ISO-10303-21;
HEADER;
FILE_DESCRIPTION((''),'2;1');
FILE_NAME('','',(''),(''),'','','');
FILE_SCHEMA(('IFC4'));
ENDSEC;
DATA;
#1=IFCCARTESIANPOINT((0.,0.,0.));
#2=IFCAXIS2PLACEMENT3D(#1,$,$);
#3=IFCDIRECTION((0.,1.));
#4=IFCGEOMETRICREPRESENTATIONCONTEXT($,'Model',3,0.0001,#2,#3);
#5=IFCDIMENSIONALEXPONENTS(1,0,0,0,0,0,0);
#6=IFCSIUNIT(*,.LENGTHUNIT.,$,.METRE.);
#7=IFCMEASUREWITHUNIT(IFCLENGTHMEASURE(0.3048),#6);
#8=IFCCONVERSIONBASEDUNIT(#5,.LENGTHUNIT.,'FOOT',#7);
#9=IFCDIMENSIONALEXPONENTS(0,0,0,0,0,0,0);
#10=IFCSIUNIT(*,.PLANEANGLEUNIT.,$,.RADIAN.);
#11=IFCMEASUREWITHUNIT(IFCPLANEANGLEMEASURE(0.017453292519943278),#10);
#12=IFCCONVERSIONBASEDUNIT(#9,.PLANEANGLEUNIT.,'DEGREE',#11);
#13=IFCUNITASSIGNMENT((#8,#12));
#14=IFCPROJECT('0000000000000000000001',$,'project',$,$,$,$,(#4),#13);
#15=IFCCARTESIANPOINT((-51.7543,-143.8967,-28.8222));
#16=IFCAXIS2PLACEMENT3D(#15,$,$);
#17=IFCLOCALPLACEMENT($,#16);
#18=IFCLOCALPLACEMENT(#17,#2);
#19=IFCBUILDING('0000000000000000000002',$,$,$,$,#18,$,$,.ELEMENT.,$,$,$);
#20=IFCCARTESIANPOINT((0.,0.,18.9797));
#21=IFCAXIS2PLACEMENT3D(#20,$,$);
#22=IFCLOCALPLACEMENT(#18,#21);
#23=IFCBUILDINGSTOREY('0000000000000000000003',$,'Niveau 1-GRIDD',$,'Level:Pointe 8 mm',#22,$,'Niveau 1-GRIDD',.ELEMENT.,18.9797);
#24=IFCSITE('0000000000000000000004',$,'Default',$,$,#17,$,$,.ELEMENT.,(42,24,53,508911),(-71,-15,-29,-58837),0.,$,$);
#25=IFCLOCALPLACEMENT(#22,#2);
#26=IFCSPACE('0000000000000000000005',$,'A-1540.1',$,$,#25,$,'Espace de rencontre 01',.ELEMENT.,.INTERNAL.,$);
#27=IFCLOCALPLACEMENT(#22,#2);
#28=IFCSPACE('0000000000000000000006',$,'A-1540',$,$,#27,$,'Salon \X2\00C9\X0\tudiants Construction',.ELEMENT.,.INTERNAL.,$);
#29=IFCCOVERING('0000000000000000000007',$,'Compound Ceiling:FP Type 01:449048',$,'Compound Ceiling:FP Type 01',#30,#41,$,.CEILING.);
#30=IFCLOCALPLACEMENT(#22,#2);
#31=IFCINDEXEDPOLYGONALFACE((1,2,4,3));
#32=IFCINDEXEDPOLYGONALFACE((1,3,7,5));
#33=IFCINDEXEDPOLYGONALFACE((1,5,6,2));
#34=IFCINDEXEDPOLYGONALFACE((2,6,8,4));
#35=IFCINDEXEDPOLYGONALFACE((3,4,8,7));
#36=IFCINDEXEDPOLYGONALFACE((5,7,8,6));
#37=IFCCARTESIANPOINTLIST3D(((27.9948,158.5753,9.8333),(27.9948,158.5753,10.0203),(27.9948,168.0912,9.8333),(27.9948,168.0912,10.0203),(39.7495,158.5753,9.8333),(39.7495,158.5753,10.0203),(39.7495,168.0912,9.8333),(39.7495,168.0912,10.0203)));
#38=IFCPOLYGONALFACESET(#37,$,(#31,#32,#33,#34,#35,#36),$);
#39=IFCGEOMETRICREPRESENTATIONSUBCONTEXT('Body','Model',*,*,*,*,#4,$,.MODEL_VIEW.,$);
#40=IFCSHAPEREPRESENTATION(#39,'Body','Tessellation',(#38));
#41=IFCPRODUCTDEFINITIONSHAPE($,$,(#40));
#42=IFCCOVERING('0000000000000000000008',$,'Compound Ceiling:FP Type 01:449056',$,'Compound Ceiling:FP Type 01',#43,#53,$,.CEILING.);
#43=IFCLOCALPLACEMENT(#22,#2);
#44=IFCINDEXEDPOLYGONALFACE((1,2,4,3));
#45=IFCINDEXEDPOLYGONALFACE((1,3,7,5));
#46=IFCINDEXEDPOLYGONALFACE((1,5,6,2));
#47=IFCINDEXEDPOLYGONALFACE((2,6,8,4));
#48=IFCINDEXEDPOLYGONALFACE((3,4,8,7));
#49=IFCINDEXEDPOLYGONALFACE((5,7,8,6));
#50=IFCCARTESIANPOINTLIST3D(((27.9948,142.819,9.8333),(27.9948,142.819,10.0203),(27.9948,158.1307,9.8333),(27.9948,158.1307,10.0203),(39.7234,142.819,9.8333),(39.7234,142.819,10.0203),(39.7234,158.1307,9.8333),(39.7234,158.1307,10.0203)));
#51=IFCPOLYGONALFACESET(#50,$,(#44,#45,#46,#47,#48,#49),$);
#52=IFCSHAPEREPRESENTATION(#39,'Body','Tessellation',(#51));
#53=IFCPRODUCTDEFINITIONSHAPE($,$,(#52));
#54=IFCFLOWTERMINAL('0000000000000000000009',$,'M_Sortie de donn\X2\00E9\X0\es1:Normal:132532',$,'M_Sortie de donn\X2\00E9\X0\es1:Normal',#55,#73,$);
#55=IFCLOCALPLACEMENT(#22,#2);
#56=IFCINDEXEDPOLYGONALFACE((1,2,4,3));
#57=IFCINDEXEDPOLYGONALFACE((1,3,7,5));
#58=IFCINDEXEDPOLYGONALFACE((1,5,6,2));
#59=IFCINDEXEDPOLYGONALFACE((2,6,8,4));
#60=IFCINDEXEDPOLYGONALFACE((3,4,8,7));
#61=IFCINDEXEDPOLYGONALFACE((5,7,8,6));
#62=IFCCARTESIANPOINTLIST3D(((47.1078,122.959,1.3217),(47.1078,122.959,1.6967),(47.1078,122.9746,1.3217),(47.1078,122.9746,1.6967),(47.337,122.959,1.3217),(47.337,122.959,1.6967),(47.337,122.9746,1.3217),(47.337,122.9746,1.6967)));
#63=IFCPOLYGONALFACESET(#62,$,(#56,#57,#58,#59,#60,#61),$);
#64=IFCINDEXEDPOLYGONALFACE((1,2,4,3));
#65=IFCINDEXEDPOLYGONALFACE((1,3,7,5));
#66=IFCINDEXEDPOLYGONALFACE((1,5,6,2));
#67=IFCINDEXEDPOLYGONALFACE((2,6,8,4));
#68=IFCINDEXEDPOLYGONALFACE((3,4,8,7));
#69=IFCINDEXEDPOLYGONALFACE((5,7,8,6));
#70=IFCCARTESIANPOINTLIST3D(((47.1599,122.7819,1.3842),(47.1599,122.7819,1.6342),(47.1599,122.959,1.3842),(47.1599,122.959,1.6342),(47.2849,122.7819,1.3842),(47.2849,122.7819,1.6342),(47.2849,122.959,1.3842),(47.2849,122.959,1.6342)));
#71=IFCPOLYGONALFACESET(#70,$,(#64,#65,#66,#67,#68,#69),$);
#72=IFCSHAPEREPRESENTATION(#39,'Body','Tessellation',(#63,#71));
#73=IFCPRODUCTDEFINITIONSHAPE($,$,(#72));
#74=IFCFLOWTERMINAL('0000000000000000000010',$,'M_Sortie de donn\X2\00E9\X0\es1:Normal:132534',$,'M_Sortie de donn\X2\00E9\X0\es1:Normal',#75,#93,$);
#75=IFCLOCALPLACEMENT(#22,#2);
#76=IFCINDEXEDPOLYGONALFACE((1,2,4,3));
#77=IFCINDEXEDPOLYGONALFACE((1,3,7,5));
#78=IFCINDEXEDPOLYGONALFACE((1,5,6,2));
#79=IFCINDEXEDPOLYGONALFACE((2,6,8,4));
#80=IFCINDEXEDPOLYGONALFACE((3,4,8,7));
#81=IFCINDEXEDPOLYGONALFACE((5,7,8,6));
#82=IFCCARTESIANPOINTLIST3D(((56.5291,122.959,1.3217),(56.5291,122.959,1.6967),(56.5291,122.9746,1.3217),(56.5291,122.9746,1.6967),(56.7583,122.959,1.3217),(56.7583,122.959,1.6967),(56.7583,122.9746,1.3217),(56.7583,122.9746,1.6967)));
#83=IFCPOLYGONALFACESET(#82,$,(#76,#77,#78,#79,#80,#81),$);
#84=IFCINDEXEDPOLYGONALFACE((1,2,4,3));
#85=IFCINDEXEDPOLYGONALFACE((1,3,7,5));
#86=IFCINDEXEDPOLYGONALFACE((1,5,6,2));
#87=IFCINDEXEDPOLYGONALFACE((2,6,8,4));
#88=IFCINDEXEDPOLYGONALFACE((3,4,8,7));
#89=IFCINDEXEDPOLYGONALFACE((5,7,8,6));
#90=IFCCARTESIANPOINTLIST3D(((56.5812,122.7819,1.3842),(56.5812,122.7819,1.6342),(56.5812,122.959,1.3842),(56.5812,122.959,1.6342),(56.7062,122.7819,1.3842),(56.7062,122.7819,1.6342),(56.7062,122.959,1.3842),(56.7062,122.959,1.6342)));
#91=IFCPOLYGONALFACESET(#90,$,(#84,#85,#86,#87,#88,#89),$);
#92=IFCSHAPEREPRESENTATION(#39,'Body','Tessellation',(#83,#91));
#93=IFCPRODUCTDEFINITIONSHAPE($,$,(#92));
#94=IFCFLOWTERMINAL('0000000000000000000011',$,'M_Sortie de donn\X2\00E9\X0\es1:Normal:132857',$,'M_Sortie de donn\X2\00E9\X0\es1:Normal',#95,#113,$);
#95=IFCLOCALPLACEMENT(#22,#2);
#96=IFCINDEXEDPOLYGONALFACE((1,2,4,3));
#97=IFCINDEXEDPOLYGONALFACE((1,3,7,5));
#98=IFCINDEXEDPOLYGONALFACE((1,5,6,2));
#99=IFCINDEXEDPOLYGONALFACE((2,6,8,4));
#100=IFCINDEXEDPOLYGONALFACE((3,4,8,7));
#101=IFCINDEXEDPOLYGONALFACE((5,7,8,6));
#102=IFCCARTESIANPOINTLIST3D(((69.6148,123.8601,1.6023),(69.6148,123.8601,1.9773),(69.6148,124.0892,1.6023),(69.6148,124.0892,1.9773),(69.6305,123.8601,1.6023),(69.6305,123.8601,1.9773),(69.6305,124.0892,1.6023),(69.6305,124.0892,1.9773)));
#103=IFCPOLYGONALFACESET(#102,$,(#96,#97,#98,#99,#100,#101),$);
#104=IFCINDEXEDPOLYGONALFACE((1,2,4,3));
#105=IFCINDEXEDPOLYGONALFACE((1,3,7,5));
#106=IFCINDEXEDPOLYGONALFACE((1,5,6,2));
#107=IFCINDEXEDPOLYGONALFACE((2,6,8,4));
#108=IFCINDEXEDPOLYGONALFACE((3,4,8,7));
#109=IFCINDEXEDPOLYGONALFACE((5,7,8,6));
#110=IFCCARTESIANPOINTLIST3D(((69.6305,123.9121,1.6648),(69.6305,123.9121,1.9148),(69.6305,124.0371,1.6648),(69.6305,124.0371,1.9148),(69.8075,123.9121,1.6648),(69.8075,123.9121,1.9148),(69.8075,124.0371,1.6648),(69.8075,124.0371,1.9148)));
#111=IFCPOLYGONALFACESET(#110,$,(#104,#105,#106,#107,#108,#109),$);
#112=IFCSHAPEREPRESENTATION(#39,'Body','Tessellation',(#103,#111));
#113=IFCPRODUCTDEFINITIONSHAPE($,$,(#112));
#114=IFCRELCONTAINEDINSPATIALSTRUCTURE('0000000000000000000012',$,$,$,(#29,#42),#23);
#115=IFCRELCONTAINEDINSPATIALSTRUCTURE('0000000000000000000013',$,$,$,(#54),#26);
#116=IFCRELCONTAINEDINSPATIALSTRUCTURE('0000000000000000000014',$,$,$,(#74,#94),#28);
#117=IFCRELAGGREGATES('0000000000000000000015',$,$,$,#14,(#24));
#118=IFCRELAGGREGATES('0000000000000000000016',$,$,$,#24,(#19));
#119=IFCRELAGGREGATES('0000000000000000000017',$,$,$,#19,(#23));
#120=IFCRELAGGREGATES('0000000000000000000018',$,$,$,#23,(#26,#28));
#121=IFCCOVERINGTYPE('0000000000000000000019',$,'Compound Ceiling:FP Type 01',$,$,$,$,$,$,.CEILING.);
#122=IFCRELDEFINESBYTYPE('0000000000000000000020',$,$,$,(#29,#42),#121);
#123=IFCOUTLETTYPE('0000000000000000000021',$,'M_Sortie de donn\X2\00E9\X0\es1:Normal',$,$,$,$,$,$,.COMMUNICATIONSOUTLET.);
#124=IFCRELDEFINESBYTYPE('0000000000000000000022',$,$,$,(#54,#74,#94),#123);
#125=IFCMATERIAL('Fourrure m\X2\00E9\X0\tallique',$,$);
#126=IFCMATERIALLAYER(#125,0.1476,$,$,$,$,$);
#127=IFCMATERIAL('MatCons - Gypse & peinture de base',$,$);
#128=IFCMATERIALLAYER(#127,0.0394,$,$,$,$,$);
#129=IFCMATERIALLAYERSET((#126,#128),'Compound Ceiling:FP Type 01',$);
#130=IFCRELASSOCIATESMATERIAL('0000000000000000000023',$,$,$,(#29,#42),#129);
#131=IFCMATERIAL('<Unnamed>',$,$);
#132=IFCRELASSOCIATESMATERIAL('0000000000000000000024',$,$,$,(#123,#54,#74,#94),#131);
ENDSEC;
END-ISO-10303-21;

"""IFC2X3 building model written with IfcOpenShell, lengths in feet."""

from ifc_helpers import new_model, entity, si_unit, converted_unit, direction, frame, frame_2d, origin, place, context, subcontext, project, spatial, rectangle, extrude, source, transform, mapped, material, layer, layer_set, layer_usage, type_object, type_shapes, element, save


model = new_model("IFC2X3")

# Units and contexts
model_context = context("Model", 3, precision=0.0001, world=origin(), true_north=direction((0.0, 1.0)))
body_context = subcontext(model_context, "Body", "Model", "MODEL_VIEW")
ifc_project = project(units=[converted_unit("LENGTHUNIT", "FOOT", entity("IfcLengthMeasure", 0.3048), si_unit("LENGTHUNIT", "METRE"), dimensions=[1, 0, 0, 0, 0, 0, 0]), converted_unit("PLANEANGLEUNIT", "DEGREE", entity("IfcPlaneAngleMeasure", 0.017453292519943278), si_unit("PLANEANGLEUNIT", "RADIAN"), dimensions=[0, 0, 0, 0, 0, 0, 0])], contexts=[model_context])

# Site, building, storey
site_placement = place(None, frame((-51.7543, -143.8967, -28.8222)))
site = spatial("IfcSite", under=ifc_project, at=site_placement, Name="Default", CompositionType="ELEMENT", RefLatitude=(42, 24, 53, 508911), RefLongitude=(-71, -15, -29, -58837), RefElevation=0.0)
building_placement = place(site_placement, origin())
building = spatial("IfcBuilding", under=site, at=building_placement, CompositionType="ELEMENT")
storey_placement = place(building_placement, frame((0.0, 0.0, 18.9797)))
storey = spatial("IfcBuildingStorey", under=building, at=storey_placement, Name="Niveau 1-GRIDD", ObjectType="Level:Pointe 8 mm", LongName="Niveau 1-GRIDD", CompositionType="ELEMENT", Elevation=18.9797)

# Shared definitions
ifc_material_1 = material(Name="<Unnamed>")

# Coverings
ifc_material_2 = material(Name="Fourrure métallique")
ifc_layer_1 = layer(ifc_material_2, 0.1476)
ifc_material_3 = material(Name="MatCons - Gypse & peinture de base")
ifc_layer_2 = layer(ifc_material_3, 0.0394)
ifc_layer_set_1 = layer_set([ifc_layer_1, ifc_layer_2], Name="Compound Ceiling:FP Type 01")
ifc_layer_usage_1 = layer_usage(ifc_layer_set_1, "AXIS3", "NEGATIVE", 0.187)
covering_type = type_object("IfcCoveringType", Name="Compound Ceiling:FP Type 01", PredefinedType="CEILING")
covering_1_placement = place(storey_placement, origin())
element("IfcCovering", 1, at=covering_1_placement, inside=storey, type_object=covering_type, material=ifc_layer_usage_1, Name="Compound Ceiling:FP Type 01:449048", ObjectType="Compound Ceiling:FP Type 01", PredefinedType="CEILING", context=body_context, shape_type="SweptSolid", body=[
    extrude(rectangle(XDim=9.5159, YDim=11.7548, at=frame_2d((0.0, 0.0), x_axis=(1.0, 0.0))), frame((33.8721, 163.3333, 9.8333), z_axis=(0.0, 0.0, 1.0), x_axis=(0.0, 1.0, 0.0)), (0.0, 0.0, 1.0), 0.187),
])
ifc_layer_usage_2 = layer_usage(ifc_layer_set_1, "AXIS3", "NEGATIVE", 0.187)
covering_2_placement = place(storey_placement, origin())
element("IfcCovering", 2, at=covering_2_placement, inside=storey, type_object=covering_type, material=ifc_layer_usage_2, Name="Compound Ceiling:FP Type 01:449056", ObjectType="Compound Ceiling:FP Type 01", PredefinedType="CEILING", context=body_context, shape_type="SweptSolid", body=[
    extrude(rectangle(XDim=11.7286, YDim=15.3118, at=frame_2d((0.0, 0.0), x_axis=(1.0, 0.0))), frame((33.8591, 150.4749, 9.8333)), (0.0, 0.0, 1.0), 0.187),
])

# Shared definitions
space_1_placement = place(storey_placement, origin())
space_1 = spatial("IfcSpace", under=storey, at=space_1_placement, Name="A-1540.1", LongName="Espace de rencontre 01", CompositionType="ELEMENT", InteriorOrExteriorSpace="INTERNAL")

# Flow terminal
outlet_type = type_object("IfcOutletType", Name="M_Sortie de données1:Normal", PredefinedType="COMMUNICATIONSOUTLET", material=ifc_material_1)
shared_shape_1 = source(origin(), body_context, "Body", "SweptSolid", [
    extrude(rectangle(XDim=0.2292, YDim=0.375, at=frame_2d((0.0, 0.0), x_axis=(1.0, 0.0))), frame((0.0, 0.0, 0.0), z_axis=(0.0, 0.0, 1.0), x_axis=(-1.0, 0.0, 0.0)), (0.0, 0.0, 1.0), 0.0156),
    extrude(rectangle(XDim=0.125, YDim=0.25, at=frame_2d((0.0, 0.0), x_axis=(1.0, 0.0))), frame((0.0, 0.0, -0.1771), z_axis=(0.0, 0.0, 1.0), x_axis=(-1.0, 0.0, 0.0)), (0.0, 0.0, 1.0), 0.1771),
])
type_shapes(outlet_type, [shared_shape_1])
flow_terminal_placement = place(space_1_placement, frame((47.2224, 122.959, 1.5092), z_axis=(0.0, 1.0, 0.0), x_axis=(-1.0, 0.0, 0.0)))
element("IfcFlowTerminal", 3, at=flow_terminal_placement, inside=space_1, type_object=outlet_type, material=ifc_material_1, Name="M_Sortie de données1:Normal:132532", ObjectType="M_Sortie de données1:Normal", context=body_context, shape_type="MappedRepresentation", body=[
    mapped(shared_shape_1, transform((0.0, 0.0, 0.0), scale=1.0)),
])

# Shared definitions
space_2_placement = place(storey_placement, origin())
space_2 = spatial("IfcSpace", under=storey, at=space_2_placement, Name="A-1540", LongName="Salon Étudiants Construction", CompositionType="ELEMENT", InteriorOrExteriorSpace="INTERNAL")

# Flow terminals
for number, where, z_axis, x_axis, name in (
    (4, (56.6437, 122.959, 1.5092), (0.0, 1.0, 0.0), (-1.0, 0.0, 0.0), "M_Sortie de données1:Normal:132534"),
    (5, (69.6305, 123.9746, 1.7898), (-1.0, 0.0, 0.0), (0.0, -1.0, 0.0), "M_Sortie de données1:Normal:132857"),
):
    element("IfcFlowTerminal", number, at=place(space_2_placement, frame(where, z_axis=z_axis, x_axis=x_axis)), inside=space_2, type_object=outlet_type, material=ifc_material_1, Name=name, ObjectType="M_Sortie de données1:Normal", context=body_context, shape_type="MappedRepresentation", body=[
        mapped(shared_shape_1, transform((0.0, 0.0, 0.0), scale=1.0)),
    ])

save(model, "model.ifc")
